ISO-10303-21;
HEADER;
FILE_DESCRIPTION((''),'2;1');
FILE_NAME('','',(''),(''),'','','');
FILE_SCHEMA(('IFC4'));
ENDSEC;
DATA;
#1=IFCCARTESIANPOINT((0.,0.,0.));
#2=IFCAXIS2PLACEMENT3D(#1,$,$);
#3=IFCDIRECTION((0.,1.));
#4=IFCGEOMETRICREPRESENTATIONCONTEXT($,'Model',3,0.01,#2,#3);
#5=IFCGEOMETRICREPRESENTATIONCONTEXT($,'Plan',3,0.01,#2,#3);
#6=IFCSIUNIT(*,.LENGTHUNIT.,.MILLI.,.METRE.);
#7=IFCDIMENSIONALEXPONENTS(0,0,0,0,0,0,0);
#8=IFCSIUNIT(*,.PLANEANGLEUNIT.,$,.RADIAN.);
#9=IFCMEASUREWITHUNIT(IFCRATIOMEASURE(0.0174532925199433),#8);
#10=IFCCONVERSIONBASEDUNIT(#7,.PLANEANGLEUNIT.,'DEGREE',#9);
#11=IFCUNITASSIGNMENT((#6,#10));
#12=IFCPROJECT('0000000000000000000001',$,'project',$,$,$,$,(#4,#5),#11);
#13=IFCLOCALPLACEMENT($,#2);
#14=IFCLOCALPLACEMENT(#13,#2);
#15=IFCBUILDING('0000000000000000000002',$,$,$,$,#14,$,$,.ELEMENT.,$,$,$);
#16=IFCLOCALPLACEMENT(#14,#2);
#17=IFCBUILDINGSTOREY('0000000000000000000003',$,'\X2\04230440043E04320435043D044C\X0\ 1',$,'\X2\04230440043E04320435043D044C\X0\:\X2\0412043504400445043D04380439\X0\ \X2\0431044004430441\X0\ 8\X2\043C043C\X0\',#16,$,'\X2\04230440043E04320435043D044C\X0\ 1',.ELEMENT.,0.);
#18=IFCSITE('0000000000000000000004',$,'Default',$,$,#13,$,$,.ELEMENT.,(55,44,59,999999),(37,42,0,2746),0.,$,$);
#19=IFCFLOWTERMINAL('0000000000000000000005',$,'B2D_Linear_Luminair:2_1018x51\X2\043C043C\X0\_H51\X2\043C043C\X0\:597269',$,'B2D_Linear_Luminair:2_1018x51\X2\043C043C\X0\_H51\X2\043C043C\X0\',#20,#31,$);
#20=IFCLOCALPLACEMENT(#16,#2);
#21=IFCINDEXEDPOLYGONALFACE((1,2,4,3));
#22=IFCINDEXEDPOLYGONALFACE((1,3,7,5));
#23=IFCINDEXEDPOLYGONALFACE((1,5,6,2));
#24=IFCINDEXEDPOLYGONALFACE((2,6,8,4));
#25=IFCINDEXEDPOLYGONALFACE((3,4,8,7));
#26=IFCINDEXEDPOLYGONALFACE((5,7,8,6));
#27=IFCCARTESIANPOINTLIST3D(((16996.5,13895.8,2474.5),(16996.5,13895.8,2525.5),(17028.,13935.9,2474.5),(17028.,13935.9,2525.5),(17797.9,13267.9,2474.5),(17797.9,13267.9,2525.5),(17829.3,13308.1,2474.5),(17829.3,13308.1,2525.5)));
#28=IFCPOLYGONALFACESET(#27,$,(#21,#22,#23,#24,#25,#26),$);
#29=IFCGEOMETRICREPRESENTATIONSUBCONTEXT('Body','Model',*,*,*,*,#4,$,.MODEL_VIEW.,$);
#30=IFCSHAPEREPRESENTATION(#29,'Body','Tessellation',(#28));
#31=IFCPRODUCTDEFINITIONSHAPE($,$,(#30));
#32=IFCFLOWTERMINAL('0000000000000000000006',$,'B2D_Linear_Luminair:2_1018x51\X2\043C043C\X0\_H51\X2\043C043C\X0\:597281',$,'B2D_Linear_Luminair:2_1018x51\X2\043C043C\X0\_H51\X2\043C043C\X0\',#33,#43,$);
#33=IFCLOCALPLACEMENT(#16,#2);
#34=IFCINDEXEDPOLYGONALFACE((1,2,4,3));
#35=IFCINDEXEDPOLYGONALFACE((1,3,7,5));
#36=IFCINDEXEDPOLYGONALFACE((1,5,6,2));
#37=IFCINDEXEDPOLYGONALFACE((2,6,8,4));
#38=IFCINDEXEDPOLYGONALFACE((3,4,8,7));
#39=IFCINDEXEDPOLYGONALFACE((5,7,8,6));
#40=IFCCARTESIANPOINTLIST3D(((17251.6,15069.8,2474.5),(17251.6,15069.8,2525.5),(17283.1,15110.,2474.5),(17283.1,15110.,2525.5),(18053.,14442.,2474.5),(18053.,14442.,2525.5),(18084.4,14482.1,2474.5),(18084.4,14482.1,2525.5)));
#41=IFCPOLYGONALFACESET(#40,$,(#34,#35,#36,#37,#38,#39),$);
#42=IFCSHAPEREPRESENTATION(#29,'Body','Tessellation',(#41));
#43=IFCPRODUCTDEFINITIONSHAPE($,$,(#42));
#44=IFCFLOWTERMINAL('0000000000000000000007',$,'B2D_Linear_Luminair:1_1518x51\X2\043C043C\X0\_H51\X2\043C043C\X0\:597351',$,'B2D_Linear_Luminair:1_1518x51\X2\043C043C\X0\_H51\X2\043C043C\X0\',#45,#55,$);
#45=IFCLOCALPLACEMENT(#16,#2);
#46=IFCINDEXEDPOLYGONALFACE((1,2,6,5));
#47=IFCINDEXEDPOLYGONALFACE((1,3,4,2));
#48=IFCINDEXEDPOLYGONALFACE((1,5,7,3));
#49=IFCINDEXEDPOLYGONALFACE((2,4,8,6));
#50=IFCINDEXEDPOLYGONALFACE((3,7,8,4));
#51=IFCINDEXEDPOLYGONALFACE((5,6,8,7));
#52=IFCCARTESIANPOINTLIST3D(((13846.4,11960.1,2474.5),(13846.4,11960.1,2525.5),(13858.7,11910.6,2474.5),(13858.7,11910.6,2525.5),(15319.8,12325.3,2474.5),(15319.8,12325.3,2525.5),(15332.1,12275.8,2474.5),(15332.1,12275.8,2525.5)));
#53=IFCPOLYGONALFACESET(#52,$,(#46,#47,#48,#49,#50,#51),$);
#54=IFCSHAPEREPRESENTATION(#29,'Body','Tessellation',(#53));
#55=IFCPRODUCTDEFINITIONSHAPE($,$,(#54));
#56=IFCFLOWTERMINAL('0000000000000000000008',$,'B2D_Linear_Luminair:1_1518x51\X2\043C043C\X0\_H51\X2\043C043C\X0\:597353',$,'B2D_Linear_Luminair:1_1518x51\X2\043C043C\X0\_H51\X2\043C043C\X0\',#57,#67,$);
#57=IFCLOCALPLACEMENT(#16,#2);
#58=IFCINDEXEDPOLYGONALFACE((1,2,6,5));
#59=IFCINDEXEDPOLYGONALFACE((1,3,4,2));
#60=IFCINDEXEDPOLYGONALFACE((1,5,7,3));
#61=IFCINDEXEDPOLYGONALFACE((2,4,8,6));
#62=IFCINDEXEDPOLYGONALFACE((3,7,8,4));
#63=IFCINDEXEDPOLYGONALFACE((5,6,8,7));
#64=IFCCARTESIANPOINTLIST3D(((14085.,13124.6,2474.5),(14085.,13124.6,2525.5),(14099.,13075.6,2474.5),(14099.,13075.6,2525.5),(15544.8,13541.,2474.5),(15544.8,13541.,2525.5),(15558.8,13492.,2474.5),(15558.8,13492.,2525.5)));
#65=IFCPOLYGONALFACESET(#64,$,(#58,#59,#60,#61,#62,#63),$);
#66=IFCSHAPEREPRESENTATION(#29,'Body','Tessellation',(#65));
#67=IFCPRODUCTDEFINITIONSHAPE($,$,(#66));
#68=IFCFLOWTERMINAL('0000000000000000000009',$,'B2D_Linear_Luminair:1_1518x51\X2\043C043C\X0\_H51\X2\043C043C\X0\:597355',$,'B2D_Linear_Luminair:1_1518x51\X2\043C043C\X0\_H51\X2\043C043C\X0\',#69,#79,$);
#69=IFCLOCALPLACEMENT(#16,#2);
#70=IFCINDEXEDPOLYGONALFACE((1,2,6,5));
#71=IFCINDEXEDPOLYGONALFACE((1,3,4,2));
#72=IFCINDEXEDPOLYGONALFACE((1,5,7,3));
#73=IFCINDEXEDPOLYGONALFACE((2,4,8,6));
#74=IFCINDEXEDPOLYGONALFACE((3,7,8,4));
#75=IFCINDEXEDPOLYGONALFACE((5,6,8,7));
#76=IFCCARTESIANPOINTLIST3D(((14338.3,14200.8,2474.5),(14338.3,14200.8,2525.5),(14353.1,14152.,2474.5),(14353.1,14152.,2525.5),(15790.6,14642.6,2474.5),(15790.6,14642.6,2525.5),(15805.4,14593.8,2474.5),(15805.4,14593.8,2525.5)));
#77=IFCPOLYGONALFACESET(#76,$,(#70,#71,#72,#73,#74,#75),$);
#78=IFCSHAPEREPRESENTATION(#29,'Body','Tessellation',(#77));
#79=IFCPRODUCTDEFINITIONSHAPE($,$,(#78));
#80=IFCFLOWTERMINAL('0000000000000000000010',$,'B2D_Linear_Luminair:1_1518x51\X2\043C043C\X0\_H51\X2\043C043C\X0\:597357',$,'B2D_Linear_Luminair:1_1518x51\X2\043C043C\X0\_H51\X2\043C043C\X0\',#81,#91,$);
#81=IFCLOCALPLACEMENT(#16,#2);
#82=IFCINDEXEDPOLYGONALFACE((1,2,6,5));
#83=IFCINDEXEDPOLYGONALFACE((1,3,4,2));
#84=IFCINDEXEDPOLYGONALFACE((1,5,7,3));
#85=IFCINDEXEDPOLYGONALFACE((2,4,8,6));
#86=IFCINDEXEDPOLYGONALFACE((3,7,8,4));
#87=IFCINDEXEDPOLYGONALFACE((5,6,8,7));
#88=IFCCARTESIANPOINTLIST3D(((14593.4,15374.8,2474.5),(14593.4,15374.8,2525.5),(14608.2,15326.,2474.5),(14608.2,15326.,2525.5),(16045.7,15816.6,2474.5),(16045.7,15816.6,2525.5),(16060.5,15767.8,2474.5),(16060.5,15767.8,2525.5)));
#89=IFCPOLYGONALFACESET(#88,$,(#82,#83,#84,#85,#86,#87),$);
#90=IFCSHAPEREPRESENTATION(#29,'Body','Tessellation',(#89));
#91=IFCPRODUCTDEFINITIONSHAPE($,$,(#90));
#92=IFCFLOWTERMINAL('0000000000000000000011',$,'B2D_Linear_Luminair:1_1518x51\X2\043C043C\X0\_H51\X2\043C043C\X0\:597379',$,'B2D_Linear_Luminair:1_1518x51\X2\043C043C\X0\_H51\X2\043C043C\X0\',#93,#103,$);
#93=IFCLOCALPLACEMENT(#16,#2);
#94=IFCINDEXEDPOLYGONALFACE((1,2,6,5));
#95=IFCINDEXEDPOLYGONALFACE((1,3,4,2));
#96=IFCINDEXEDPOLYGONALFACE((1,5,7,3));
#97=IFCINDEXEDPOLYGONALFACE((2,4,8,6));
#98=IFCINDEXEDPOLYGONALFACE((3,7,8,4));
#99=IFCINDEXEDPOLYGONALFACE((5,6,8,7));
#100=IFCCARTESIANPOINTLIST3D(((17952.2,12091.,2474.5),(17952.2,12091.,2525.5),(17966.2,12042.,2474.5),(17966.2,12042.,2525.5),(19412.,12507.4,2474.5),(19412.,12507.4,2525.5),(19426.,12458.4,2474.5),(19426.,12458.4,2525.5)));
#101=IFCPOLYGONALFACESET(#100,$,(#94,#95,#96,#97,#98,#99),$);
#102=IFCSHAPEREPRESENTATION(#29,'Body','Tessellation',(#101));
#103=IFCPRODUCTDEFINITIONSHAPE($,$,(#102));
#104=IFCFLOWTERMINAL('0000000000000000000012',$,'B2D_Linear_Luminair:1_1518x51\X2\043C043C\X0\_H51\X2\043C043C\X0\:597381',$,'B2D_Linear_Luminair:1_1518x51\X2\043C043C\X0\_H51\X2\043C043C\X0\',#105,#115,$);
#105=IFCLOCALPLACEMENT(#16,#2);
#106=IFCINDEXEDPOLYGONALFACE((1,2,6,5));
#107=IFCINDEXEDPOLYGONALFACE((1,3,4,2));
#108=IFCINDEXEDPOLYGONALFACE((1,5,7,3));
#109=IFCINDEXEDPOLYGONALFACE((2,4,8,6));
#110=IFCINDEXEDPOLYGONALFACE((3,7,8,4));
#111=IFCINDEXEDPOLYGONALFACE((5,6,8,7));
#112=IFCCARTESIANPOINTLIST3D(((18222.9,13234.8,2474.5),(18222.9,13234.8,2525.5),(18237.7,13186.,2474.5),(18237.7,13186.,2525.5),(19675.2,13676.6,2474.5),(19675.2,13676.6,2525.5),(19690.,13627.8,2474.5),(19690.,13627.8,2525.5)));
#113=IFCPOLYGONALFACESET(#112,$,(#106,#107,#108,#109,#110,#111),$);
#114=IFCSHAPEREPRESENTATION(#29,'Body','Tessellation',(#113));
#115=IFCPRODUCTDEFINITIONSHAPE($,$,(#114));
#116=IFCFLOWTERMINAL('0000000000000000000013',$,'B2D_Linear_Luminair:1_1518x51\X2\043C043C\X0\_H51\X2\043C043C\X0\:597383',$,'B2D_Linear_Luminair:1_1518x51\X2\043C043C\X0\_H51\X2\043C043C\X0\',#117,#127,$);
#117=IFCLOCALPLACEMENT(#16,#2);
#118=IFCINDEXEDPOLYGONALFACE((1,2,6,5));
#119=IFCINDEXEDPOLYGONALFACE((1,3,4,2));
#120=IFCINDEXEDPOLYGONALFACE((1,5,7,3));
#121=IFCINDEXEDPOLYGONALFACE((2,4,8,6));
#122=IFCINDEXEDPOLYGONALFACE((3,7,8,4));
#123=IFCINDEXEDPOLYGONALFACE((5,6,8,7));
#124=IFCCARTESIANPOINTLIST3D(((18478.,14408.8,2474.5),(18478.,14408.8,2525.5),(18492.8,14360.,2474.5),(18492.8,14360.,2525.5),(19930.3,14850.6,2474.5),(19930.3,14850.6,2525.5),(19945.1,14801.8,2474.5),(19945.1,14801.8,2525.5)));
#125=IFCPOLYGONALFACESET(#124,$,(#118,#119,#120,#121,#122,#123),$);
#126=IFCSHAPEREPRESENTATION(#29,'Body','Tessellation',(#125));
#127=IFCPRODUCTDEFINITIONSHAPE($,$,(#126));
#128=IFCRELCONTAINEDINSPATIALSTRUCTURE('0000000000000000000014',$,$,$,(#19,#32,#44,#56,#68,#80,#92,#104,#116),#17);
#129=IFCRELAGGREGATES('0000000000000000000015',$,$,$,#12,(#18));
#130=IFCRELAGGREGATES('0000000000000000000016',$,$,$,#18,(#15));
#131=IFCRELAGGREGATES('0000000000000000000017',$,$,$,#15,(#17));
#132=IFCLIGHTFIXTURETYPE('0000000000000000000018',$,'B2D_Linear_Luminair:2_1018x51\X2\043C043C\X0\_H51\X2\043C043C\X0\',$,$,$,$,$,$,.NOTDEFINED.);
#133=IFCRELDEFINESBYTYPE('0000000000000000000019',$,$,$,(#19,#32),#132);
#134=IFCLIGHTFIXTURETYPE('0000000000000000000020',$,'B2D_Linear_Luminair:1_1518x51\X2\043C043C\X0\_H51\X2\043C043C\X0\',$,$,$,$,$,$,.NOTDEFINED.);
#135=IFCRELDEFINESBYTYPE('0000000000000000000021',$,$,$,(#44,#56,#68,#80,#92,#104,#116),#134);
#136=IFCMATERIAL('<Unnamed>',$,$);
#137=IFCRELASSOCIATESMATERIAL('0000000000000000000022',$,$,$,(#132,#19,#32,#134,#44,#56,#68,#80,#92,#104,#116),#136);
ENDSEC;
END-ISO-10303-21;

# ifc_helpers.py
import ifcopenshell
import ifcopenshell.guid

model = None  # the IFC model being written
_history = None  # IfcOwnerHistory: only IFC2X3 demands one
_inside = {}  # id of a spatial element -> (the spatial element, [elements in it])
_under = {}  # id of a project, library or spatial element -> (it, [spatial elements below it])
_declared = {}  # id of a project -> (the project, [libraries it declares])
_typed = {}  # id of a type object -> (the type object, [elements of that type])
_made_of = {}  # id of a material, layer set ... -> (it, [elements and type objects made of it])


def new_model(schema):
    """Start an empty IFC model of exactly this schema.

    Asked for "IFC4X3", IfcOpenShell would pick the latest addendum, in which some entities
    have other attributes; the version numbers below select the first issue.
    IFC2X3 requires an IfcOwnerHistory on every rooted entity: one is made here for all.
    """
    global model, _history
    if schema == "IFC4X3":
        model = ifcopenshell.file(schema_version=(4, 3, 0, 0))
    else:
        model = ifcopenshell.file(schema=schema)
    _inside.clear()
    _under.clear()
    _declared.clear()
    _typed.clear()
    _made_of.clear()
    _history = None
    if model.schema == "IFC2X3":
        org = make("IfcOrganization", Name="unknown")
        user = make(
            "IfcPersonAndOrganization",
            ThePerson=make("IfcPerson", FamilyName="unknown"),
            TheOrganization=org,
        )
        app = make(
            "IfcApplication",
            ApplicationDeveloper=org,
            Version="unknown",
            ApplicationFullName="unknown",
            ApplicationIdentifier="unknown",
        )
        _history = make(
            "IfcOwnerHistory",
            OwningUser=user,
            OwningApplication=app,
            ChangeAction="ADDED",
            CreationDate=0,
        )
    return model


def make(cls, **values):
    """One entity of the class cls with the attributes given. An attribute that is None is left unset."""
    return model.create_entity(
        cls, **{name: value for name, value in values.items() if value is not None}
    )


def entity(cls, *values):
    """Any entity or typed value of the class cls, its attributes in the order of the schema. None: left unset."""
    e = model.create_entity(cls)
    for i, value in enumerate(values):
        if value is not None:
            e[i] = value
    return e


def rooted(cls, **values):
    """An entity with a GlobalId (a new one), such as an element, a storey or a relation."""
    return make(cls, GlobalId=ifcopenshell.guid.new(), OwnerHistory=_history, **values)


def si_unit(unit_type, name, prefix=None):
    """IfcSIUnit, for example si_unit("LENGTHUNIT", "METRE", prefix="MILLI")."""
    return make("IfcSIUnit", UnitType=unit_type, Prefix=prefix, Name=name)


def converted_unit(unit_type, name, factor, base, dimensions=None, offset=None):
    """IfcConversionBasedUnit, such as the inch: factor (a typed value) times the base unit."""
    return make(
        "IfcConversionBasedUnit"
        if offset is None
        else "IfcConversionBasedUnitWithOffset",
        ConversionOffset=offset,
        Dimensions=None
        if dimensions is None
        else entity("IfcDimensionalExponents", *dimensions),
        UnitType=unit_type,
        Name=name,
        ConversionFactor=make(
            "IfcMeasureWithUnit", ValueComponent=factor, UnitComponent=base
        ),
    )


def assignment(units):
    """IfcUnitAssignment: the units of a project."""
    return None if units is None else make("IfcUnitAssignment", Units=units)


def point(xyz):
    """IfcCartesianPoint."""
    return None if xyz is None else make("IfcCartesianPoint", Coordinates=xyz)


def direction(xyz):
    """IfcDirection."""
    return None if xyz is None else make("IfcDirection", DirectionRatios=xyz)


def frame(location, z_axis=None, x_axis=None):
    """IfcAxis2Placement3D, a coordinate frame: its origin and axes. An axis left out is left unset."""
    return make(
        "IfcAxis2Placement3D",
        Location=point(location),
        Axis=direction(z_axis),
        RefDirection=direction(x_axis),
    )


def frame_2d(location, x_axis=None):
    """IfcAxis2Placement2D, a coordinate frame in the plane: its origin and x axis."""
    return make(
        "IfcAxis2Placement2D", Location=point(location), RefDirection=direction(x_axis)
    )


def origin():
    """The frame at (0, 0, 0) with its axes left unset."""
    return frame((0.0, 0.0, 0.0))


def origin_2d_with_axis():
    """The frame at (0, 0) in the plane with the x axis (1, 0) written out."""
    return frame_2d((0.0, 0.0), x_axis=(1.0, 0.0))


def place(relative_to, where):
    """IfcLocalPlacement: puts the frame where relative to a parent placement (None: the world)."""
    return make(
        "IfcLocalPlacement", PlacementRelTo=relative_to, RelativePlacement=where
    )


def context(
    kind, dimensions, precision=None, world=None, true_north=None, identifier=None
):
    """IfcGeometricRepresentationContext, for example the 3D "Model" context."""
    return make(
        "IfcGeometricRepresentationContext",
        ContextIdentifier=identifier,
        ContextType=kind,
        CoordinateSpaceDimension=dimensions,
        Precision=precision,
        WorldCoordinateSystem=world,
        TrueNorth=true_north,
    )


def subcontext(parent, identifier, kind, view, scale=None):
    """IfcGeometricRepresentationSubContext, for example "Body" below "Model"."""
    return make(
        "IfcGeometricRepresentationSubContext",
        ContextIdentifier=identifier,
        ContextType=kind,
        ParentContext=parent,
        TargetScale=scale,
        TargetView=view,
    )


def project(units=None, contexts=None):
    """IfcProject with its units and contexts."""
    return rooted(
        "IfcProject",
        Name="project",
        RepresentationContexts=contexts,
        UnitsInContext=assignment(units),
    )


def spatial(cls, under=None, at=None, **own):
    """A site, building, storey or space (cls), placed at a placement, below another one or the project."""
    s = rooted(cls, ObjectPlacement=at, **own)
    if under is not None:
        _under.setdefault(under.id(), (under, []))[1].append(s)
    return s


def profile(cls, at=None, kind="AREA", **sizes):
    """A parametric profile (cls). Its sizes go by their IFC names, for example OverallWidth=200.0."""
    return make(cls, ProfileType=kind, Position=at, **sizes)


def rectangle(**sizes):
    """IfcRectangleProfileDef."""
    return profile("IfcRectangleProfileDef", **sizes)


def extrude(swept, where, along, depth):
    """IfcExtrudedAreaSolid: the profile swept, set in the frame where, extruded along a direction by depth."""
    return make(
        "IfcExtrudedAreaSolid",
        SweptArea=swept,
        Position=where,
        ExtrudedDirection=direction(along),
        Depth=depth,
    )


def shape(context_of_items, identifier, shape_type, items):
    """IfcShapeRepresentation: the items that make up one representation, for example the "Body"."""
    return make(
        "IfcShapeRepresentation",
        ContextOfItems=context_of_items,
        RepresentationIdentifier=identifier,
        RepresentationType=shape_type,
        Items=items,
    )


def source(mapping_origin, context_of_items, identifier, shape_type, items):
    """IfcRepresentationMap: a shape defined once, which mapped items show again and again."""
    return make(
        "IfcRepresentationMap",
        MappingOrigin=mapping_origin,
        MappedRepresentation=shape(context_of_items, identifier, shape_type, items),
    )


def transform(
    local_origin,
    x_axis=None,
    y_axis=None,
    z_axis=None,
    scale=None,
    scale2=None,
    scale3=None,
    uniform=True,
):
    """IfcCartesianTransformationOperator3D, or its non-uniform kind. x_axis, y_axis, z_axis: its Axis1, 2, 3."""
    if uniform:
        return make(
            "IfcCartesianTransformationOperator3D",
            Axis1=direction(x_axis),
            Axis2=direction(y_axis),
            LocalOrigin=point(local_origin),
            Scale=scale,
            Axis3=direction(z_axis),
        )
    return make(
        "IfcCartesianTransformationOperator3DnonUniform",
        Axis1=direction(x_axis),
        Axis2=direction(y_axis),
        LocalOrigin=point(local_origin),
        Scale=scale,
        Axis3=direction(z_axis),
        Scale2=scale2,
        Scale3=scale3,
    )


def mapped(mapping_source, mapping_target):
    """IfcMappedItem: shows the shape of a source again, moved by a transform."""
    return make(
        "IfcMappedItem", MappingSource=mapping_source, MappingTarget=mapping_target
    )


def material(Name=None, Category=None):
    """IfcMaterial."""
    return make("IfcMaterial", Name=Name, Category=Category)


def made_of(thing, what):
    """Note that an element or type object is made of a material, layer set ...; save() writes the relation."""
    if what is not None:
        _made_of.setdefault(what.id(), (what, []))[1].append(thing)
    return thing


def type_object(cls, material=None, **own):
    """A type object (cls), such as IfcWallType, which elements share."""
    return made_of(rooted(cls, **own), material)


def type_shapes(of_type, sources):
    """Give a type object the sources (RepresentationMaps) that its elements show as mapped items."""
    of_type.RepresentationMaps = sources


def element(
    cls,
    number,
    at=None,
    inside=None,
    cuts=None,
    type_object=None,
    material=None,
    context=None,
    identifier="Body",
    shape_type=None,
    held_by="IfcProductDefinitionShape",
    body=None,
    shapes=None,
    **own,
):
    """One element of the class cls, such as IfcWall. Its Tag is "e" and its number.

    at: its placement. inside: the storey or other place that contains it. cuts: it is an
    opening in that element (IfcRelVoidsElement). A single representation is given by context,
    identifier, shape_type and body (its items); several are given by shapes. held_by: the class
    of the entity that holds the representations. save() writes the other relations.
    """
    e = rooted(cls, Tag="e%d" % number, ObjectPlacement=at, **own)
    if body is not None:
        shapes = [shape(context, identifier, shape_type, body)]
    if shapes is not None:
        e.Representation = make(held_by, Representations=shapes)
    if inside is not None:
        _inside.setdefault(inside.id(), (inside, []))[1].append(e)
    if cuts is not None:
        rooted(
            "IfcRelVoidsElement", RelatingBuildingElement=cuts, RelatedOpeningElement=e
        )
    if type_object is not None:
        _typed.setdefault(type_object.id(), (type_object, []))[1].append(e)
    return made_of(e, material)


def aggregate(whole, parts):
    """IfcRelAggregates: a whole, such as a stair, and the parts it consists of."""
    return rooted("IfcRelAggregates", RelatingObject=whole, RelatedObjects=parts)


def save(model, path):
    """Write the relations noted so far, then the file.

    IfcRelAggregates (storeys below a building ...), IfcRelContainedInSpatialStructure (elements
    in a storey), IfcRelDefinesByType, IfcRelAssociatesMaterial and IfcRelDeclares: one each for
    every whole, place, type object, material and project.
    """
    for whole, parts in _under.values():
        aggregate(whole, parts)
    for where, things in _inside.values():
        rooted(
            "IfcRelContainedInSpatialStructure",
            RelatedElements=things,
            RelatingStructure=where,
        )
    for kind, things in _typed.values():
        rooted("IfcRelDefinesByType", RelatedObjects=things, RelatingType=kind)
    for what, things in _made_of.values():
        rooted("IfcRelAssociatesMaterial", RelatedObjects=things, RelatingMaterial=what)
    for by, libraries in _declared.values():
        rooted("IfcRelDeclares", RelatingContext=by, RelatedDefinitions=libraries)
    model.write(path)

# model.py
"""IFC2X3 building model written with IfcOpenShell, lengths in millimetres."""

from ifc_helpers import new_model, entity, si_unit, converted_unit, direction, frame, origin, origin_2d_with_axis, place, context, subcontext, project, spatial, rectangle, extrude, source, transform, mapped, material, type_object, type_shapes, element, save


model = new_model("IFC2X3")

# Units and contexts
model_context = context("Model", 3, precision=0.01, world=origin(), true_north=direction((0.0, 1.0)))
plan_context = context("Plan", 3, precision=0.01, world=origin(), true_north=direction((0.0, 1.0)))
body_context = subcontext(model_context, "Body", "Model", "MODEL_VIEW")
ifc_project = project(units=[si_unit("LENGTHUNIT", "METRE", prefix="MILLI"), converted_unit("PLANEANGLEUNIT", "DEGREE", entity("IfcRatioMeasure", 0.0174532925199433), si_unit("PLANEANGLEUNIT", "RADIAN"), dimensions=[0, 0, 0, 0, 0, 0, 0])], contexts=[model_context, plan_context])

# Site, building, storey
site_placement = place(None, origin())
site = spatial("IfcSite", under=ifc_project, at=site_placement, Name="Default", CompositionType="ELEMENT", RefLatitude=(55, 44, 59, 999999), RefLongitude=(37, 42, 0, 2746), RefElevation=0.0)
building_placement = place(site_placement, origin())
building = spatial("IfcBuilding", under=site, at=building_placement, CompositionType="ELEMENT")
storey_placement = place(building_placement, origin())
storey = spatial("IfcBuildingStorey", under=building, at=storey_placement, Name="Уровень 1", ObjectType="Уровень:Верхний брус 8мм", LongName="Уровень 1", CompositionType="ELEMENT", Elevation=0.0)

# Flow terminals
ifc_material = material(Name="<Unnamed>")
light_fixture_type_1 = type_object("IfcLightFixtureType", Name="B2D_Linear_Luminair:2_1018x51мм_H51мм", PredefinedType="NOTDEFINED", material=ifc_material)
shared_shape_1 = source(origin(), body_context, "Body", "SweptSolid", [
    extrude(rectangle(XDim=1018.0, YDim=51.0, at=origin_2d_with_axis()), frame((0.0, 0.0, 0.0), z_axis=(0.0, 0.0, 1.0), x_axis=(-1.0, 0.0, 0.0)), (0.0, 0.0, 1.0), 51.0),
])
type_shapes(light_fixture_type_1, [shared_shape_1])
for number, where, z_axis, x_axis, name in (
    (1, (17412.9, 13601.9, 2525.5), (0.0, 0.0, -1.0), (0.78715, -0.616761, 0.0), "B2D_Linear_Luminair:2_1018x51мм_H51мм:597269"),
    (2, (17668.0, 14776.0, 2525.5), (0.0, 0.0, -1.0), (0.78715, -0.616761, 0.0), "B2D_Linear_Luminair:2_1018x51мм_H51мм:597281"),
):
    element("IfcFlowTerminal", number, at=place(storey_placement, frame(where, z_axis=z_axis, x_axis=x_axis)), inside=storey, type_object=light_fixture_type_1, material=ifc_material, Name=name, ObjectType="B2D_Linear_Luminair:2_1018x51мм_H51мм", context=body_context, shape_type="MappedRepresentation", body=[
        mapped(shared_shape_1, transform((0.0, 0.0, 0.0), scale=1.0)),
    ])
light_fixture_type_2 = type_object("IfcLightFixtureType", Name="B2D_Linear_Luminair:1_1518x51мм_H51мм", PredefinedType="NOTDEFINED", material=ifc_material)
shared_shape_2 = source(origin(), body_context, "Body", "SweptSolid", [
    extrude(rectangle(XDim=1518.0, YDim=51.0, at=origin_2d_with_axis()), frame((0.0, 0.0, 0.0), z_axis=(0.0, 0.0, 1.0), x_axis=(-1.0, 0.0, 0.0)), (0.0, 0.0, 1.0), 51.0),
])
type_shapes(light_fixture_type_2, [shared_shape_2])
for number, where, z_axis, x_axis, name in (
    (3, (14589.2, 12118.0, 2525.5), (0.0, 0.0, -1.0), (0.970633, 0.240567, 0.0), "B2D_Linear_Luminair:1_1518x51мм_H51мм:597351"),
    (4, (14821.9, 13308.3, 2525.5), (0.0, 0.0, -1.0), (0.961646, 0.274295, 0.0), "B2D_Linear_Luminair:1_1518x51мм_H51мм:597353"),
    (5, (15071.8, 14397.3, 2525.5), (0.0, 0.0, -1.0), (0.956712, 0.291036, 0.0), "B2D_Linear_Luminair:1_1518x51мм_H51мм:597355"),
    (6, (15327.0, 15571.3, 2525.5), (0.0, 0.0, -1.0), (0.956712, 0.291036, 0.0), "B2D_Linear_Luminair:1_1518x51мм_H51мм:597357"),
    (7, (18689.1, 12274.7, 2525.5), (0.0, 0.0, -1.0), (0.961646, 0.274295, 0.0), "B2D_Linear_Luminair:1_1518x51мм_H51мм:597379"),
    (8, (18956.5, 13431.3, 2525.5), (0.0, 0.0, -1.0), (0.956712, 0.291036, 0.0), "B2D_Linear_Luminair:1_1518x51мм_H51мм:597381"),
    (9, (19211.6, 14605.3, 2525.5), (0.0, 0.0, -1.0), (0.956712, 0.291036, 0.0), "B2D_Linear_Luminair:1_1518x51мм_H51мм:597383"),
):
    element("IfcFlowTerminal", number, at=place(storey_placement, frame(where, z_axis=z_axis, x_axis=x_axis)), inside=storey, type_object=light_fixture_type_2, material=ifc_material, Name=name, ObjectType="B2D_Linear_Luminair:1_1518x51мм_H51мм", context=body_context, shape_type="MappedRepresentation", body=[
        mapped(shared_shape_2, transform((0.0, 0.0, 0.0), scale=1.0)),
    ])

save(model, "model.ifc")
